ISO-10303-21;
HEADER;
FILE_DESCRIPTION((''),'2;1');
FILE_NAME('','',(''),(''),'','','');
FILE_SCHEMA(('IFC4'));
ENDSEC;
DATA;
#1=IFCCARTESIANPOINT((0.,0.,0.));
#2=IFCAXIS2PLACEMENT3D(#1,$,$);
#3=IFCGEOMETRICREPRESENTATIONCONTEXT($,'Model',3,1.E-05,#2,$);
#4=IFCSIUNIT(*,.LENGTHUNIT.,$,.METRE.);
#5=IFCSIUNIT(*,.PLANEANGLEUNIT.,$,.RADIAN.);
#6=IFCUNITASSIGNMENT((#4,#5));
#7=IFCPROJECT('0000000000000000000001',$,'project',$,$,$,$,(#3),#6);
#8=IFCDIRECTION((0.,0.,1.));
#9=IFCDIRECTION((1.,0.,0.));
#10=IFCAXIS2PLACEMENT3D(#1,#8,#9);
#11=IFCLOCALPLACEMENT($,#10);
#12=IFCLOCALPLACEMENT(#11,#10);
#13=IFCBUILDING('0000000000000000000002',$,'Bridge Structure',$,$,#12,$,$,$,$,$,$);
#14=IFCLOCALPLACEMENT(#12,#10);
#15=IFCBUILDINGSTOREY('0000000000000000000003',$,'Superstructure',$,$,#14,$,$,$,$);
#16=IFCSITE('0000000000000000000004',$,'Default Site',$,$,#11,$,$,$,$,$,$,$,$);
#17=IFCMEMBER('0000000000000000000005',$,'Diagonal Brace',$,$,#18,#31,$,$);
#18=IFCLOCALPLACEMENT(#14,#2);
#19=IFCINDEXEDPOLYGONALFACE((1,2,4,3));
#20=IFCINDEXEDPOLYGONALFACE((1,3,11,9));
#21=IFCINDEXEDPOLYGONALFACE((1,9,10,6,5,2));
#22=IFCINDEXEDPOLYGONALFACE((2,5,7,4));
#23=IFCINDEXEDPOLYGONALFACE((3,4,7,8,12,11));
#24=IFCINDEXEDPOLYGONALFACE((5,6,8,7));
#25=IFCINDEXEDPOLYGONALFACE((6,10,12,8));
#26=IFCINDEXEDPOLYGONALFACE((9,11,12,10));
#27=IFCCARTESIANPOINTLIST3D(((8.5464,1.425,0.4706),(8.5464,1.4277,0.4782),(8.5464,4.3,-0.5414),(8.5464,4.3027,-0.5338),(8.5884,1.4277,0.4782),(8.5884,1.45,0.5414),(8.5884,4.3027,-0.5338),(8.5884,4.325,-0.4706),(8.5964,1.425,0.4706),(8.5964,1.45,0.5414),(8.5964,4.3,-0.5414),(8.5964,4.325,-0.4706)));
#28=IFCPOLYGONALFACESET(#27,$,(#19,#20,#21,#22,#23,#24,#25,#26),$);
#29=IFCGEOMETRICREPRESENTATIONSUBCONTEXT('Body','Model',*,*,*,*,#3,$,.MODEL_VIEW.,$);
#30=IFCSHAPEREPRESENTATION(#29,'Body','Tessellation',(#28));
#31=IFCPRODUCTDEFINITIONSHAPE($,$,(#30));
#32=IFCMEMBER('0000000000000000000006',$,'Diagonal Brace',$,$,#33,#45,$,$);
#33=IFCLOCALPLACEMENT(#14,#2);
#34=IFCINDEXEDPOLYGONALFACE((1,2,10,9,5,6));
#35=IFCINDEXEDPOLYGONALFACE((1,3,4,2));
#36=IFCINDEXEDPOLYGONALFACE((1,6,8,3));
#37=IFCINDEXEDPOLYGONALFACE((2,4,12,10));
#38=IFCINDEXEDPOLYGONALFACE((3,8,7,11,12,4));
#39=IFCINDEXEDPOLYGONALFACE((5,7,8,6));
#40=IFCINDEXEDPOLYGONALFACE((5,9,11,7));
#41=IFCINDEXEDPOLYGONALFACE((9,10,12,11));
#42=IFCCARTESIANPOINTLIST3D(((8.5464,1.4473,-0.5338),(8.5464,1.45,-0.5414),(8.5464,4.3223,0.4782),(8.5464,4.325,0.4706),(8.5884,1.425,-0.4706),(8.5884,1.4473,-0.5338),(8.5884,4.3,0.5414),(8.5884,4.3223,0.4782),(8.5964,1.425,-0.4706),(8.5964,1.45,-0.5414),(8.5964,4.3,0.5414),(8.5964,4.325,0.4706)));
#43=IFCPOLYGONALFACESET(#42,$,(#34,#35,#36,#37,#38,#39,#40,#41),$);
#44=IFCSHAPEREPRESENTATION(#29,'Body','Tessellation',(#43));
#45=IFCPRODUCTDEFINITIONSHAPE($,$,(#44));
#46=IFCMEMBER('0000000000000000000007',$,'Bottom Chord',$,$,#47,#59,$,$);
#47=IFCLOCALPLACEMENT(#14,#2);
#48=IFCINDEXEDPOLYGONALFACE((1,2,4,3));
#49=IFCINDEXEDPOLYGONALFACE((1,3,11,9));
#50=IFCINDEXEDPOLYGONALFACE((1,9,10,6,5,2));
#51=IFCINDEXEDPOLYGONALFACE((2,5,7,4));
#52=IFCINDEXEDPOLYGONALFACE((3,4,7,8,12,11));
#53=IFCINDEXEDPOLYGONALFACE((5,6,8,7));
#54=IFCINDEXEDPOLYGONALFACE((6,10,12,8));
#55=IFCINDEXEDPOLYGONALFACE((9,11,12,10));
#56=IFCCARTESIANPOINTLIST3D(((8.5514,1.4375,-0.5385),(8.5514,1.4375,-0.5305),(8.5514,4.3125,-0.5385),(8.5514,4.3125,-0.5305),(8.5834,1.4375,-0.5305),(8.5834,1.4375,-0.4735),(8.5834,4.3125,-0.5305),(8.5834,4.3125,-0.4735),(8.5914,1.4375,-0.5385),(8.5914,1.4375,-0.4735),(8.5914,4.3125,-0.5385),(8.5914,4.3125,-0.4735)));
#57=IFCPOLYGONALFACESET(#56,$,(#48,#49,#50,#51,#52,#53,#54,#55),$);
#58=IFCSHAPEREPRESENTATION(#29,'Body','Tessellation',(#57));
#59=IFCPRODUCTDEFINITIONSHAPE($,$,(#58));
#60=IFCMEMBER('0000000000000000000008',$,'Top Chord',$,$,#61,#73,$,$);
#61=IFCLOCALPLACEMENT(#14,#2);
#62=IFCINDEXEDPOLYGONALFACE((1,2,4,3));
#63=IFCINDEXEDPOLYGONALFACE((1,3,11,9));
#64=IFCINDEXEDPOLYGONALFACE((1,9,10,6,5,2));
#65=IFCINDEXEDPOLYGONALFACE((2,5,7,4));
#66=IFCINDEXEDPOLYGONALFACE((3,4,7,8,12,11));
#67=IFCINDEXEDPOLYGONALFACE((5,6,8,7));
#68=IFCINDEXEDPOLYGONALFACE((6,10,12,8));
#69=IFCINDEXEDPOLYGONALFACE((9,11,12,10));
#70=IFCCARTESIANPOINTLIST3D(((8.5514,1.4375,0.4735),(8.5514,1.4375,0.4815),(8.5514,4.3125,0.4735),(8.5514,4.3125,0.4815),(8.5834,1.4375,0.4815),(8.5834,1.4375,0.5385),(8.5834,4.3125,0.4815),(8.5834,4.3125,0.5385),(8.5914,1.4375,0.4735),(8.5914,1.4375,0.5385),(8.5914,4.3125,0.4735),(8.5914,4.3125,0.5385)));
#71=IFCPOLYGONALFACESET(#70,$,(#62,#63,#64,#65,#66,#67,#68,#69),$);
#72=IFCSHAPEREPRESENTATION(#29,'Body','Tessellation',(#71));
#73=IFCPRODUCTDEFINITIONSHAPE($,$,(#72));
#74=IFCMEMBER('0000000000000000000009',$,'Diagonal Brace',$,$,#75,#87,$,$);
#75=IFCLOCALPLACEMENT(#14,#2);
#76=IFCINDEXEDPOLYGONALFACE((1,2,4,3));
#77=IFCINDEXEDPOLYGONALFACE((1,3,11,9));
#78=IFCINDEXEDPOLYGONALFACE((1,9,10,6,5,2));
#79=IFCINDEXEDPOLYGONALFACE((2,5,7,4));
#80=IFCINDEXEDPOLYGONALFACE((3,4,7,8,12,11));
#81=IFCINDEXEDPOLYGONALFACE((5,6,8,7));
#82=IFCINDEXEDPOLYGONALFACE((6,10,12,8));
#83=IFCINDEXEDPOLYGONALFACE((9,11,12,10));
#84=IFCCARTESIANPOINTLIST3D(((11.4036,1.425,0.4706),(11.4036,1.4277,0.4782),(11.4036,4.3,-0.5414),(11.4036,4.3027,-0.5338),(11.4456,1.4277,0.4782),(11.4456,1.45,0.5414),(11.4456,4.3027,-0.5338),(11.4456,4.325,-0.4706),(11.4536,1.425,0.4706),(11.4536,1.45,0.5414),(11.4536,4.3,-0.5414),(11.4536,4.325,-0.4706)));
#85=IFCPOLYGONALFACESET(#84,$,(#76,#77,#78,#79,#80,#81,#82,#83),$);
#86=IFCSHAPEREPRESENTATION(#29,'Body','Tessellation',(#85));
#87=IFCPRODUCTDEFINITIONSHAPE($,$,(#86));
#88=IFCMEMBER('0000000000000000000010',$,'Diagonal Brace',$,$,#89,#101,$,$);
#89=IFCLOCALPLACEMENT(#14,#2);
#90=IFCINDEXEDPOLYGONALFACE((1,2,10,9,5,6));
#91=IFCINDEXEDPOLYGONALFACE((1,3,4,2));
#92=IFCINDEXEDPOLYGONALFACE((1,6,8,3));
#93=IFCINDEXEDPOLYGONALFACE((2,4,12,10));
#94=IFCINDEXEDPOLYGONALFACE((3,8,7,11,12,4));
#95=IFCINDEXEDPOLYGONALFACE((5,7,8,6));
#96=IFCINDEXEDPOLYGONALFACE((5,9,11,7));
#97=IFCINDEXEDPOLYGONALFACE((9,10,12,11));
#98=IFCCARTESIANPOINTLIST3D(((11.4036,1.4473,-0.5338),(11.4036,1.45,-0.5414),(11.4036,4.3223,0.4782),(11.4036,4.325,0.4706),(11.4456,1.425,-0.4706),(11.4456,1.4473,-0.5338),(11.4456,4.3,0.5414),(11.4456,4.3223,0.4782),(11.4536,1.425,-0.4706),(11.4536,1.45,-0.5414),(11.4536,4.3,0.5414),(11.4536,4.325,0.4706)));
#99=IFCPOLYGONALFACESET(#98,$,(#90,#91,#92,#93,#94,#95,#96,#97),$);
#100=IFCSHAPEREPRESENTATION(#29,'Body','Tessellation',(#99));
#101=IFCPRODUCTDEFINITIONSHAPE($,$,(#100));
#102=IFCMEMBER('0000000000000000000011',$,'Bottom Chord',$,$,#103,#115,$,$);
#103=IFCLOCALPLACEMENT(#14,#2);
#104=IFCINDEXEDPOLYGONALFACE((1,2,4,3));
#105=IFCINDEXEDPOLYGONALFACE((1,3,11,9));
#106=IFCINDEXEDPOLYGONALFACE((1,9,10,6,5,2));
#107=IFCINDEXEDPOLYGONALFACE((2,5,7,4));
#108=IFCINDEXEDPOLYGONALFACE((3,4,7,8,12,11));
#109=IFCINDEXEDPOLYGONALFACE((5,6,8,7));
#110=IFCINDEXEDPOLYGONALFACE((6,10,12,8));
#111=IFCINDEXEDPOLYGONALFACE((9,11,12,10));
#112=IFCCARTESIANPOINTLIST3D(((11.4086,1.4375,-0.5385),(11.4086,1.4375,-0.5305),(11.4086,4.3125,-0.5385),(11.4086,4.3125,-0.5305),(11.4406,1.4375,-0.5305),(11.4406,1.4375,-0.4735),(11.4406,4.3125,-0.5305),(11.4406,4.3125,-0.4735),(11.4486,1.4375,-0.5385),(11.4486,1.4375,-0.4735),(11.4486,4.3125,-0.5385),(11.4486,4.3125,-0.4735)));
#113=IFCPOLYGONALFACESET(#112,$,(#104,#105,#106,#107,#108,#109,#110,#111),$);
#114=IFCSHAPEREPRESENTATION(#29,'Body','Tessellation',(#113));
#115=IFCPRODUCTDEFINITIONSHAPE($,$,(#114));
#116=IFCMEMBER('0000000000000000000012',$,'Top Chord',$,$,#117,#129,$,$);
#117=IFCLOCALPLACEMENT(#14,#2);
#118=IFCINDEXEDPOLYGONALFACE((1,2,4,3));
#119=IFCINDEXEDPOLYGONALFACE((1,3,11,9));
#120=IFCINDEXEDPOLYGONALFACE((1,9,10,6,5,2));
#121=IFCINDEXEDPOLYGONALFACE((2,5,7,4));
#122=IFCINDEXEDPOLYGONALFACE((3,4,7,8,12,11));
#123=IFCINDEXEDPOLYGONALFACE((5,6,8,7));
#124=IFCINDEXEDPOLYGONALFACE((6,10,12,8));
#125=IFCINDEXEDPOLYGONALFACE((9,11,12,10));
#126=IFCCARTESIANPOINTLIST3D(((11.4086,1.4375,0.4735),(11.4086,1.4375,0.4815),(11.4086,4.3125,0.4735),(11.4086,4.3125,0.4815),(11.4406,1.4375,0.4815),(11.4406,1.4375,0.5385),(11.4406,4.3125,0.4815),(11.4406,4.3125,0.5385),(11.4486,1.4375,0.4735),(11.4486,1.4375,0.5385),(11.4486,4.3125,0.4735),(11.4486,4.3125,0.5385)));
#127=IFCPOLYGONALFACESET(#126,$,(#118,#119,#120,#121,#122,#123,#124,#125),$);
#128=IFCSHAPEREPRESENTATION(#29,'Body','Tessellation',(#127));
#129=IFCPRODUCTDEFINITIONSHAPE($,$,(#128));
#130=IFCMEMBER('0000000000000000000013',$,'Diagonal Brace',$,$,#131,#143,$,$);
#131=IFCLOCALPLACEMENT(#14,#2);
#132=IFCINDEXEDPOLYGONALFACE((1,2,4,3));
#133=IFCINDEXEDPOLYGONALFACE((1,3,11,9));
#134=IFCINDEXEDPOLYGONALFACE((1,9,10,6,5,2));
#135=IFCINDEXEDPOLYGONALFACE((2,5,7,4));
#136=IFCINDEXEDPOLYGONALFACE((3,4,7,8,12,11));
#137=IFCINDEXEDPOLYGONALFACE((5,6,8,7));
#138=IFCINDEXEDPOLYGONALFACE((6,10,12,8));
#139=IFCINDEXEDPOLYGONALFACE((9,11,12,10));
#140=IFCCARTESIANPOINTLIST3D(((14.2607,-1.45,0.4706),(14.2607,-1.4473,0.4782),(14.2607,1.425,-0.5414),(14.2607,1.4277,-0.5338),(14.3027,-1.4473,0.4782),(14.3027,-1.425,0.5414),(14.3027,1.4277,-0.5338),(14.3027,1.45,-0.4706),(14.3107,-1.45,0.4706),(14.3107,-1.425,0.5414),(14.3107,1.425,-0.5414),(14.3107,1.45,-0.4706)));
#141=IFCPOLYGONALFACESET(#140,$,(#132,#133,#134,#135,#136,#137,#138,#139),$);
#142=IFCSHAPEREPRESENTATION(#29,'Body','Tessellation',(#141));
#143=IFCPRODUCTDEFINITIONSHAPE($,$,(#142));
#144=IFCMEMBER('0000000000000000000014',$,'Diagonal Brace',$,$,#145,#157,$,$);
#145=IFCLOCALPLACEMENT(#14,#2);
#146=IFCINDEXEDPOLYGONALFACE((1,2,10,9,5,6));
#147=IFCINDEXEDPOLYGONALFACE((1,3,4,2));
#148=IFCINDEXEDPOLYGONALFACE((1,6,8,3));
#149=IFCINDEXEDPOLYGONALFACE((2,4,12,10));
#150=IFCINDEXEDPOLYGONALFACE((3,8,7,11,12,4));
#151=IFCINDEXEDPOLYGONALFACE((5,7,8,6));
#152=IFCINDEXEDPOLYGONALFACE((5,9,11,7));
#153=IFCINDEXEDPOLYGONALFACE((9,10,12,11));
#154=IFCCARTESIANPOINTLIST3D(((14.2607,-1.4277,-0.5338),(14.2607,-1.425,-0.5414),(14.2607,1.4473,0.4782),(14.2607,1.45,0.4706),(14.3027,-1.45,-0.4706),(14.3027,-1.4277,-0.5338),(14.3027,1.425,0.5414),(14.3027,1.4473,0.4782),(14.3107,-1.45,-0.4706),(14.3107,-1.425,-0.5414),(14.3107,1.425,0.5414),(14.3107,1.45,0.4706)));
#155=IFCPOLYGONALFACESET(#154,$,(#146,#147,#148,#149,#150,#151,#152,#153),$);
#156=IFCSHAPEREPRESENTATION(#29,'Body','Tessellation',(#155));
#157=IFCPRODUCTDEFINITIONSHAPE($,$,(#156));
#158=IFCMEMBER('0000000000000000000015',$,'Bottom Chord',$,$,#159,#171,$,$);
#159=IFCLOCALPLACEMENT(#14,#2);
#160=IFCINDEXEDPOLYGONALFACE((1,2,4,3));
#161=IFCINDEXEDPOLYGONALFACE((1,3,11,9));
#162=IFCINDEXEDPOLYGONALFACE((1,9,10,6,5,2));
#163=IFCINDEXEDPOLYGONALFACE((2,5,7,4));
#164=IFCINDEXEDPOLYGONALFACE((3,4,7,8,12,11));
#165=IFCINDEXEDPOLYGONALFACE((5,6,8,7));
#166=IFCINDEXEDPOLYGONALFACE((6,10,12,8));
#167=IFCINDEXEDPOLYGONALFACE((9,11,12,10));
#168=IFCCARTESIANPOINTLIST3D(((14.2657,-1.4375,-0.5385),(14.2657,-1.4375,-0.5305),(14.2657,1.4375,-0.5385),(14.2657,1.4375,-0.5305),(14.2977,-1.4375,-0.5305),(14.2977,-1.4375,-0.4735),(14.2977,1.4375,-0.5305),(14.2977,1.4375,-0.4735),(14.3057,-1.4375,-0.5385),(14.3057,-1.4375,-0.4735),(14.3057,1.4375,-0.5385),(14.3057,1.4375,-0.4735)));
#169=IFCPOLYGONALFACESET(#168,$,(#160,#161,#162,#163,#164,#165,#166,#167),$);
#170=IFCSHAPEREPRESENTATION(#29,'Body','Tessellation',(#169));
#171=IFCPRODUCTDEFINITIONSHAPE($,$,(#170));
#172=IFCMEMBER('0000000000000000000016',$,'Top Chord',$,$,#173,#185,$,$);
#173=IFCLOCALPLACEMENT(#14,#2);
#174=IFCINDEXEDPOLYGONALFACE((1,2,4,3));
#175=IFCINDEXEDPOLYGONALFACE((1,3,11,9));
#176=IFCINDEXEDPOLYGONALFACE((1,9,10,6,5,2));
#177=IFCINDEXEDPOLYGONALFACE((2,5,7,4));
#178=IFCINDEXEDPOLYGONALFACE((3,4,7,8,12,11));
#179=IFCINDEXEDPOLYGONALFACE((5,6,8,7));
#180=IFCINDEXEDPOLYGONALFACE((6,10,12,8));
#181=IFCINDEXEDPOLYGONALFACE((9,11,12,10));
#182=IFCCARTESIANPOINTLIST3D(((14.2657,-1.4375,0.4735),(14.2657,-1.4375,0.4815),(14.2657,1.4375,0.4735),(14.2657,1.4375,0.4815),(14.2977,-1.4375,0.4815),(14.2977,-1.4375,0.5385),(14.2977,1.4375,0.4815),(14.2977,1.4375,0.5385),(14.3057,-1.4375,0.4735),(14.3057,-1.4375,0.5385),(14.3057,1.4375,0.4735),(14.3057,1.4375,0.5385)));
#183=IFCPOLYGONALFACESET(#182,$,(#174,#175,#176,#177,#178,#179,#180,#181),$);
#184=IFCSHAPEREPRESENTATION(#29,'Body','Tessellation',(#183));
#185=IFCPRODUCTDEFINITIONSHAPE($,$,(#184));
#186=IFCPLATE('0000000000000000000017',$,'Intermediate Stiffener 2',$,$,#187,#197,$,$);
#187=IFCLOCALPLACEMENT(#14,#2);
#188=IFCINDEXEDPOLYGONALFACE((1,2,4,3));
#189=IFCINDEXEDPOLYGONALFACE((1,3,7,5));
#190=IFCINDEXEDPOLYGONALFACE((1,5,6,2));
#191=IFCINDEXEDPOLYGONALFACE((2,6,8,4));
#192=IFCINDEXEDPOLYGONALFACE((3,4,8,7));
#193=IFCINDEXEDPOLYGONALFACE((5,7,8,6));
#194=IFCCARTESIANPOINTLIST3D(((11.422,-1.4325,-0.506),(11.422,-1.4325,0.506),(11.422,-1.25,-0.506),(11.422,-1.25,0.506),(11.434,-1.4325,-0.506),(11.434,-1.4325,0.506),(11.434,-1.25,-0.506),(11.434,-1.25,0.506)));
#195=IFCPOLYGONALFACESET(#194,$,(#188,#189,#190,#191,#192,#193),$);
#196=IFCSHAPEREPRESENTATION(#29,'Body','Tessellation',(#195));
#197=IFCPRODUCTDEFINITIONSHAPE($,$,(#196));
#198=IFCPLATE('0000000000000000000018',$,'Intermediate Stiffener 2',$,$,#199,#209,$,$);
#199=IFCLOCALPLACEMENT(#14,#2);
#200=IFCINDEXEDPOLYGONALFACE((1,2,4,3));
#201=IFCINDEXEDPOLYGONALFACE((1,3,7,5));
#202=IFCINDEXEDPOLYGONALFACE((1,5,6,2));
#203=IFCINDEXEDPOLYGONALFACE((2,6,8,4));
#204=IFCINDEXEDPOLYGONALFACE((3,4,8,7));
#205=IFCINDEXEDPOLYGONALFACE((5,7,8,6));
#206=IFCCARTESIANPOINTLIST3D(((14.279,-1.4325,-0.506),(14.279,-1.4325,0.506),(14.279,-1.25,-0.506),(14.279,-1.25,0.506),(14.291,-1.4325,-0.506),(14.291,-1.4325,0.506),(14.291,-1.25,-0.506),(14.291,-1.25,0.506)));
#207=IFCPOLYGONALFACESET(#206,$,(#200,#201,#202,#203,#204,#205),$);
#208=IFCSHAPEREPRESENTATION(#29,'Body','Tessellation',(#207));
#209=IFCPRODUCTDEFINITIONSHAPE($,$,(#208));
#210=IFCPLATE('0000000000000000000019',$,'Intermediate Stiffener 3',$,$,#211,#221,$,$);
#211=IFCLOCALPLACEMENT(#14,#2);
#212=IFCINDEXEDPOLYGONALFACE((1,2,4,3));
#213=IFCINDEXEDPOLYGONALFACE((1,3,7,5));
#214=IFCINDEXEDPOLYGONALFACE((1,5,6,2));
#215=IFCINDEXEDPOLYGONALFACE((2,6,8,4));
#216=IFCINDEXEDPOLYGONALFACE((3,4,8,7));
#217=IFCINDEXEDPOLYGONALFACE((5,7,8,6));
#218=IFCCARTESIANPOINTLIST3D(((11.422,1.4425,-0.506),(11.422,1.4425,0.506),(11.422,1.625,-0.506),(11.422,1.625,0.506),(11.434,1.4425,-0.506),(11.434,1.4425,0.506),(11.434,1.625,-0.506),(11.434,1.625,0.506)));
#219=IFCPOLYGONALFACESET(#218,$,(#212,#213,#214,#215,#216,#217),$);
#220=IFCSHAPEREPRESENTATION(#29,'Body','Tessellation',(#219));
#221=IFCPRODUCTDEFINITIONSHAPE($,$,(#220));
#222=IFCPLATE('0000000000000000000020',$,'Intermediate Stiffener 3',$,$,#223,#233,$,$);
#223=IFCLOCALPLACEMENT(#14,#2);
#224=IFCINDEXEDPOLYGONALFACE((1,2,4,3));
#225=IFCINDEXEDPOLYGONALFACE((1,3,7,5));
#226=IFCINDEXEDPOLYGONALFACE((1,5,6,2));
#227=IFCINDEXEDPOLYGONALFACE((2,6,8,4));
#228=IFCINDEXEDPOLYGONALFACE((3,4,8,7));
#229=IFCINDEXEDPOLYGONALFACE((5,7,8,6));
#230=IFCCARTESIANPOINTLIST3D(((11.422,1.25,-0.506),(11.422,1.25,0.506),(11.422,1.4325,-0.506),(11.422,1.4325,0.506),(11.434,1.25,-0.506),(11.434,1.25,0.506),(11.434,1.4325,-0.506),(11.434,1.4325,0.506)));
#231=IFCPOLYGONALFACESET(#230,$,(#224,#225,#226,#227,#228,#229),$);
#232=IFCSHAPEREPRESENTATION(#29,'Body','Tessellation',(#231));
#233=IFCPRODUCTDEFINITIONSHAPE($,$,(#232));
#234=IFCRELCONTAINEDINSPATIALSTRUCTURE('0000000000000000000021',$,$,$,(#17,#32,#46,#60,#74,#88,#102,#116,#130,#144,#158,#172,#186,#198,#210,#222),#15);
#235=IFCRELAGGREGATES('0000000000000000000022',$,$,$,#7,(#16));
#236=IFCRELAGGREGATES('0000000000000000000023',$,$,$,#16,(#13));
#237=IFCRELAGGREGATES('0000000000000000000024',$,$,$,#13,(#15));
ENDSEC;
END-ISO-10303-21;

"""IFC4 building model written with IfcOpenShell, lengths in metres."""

from ifc_helpers import new_model, si_unit, frame, origin, origin_with_axes, origin_2d_with_axis, place, context, subcontext, project, spatial, rectangle, l_section, extrude, element, save


model = new_model("IFC4")

# Units and contexts
model_context = context("Model", 3, precision=1e-05, world=origin())
body_context = subcontext(model_context, "Body", "Model", "MODEL_VIEW")
ifc_project = project(units=[si_unit("LENGTHUNIT", "METRE"), si_unit("PLANEANGLEUNIT", "RADIAN")], contexts=[model_context])

# Site, building, storey
site_placement = place(None, origin_with_axes())
site = spatial("IfcSite", under=ifc_project, at=site_placement, Name="Default Site")
building_placement = place(site_placement, origin_with_axes())
building = spatial("IfcBuilding", under=site, at=building_placement, Name="Bridge Structure")
storey_placement = place(building_placement, origin_with_axes())
storey = spatial("IfcBuildingStorey", under=building, at=storey_placement, Name="Superstructure")

# Members
for number, where, z_axis, x_axis, name in (
    (1, (8.5714, 1.4375, 0.506), (0.0, 0.943269, -0.332031), (-1.0, 0.0, 0.0), "Diagonal Brace"),
    (2, (8.5714, 1.4375, -0.506), (0.0, 0.943269, 0.332031), (-1.0, 0.0, 0.0), "Diagonal Brace"),
):
    element("IfcMember", number, at=place(storey_placement, frame(where, z_axis=z_axis, x_axis=x_axis)), inside=storey, Name=name, context=body_context, shape_type="SweptSolid", body=[
        extrude(l_section(Depth=0.075, Width=0.05, Thickness=0.008, at=origin_2d_with_axis()), origin_with_axes(), (0.0, 0.0, 1.0), 3.0479),
    ])
for number, where, z_axis, x_axis, name in (
    (3, (8.5714, 1.4375, -0.506), (0.0, 1.0, 0.0), (-1.0, 0.0, 0.0), "Bottom Chord"),
    (4, (8.5714, 1.4375, 0.506), (0.0, 1.0, 0.0), (-1.0, 0.0, 0.0), "Top Chord"),
):
    element("IfcMember", number, at=place(storey_placement, frame(where, z_axis=z_axis, x_axis=x_axis)), inside=storey, Name=name, context=body_context, shape_type="SweptSolid", body=[
        extrude(l_section(Depth=0.065, Width=0.04, Thickness=0.008, at=origin_2d_with_axis()), origin_with_axes(), (0.0, 0.0, 1.0), 2.875),
    ])
for number, where, z_axis, x_axis, name in (
    (5, (11.4286, 1.4375, 0.506), (0.0, 0.943269, -0.332031), (-1.0, 0.0, 0.0), "Diagonal Brace"),
    (6, (11.4286, 1.4375, -0.506), (0.0, 0.943269, 0.332031), (-1.0, 0.0, 0.0), "Diagonal Brace"),
):
    element("IfcMember", number, at=place(storey_placement, frame(where, z_axis=z_axis, x_axis=x_axis)), inside=storey, Name=name, context=body_context, shape_type="SweptSolid", body=[
        extrude(l_section(Depth=0.075, Width=0.05, Thickness=0.008, at=origin_2d_with_axis()), origin_with_axes(), (0.0, 0.0, 1.0), 3.0479),
    ])
for number, where, z_axis, x_axis, name in (
    (7, (11.4286, 1.4375, -0.506), (0.0, 1.0, 0.0), (-1.0, 0.0, 0.0), "Bottom Chord"),
    (8, (11.4286, 1.4375, 0.506), (0.0, 1.0, 0.0), (-1.0, 0.0, 0.0), "Top Chord"),
):
    element("IfcMember", number, at=place(storey_placement, frame(where, z_axis=z_axis, x_axis=x_axis)), inside=storey, Name=name, context=body_context, shape_type="SweptSolid", body=[
        extrude(l_section(Depth=0.065, Width=0.04, Thickness=0.008, at=origin_2d_with_axis()), origin_with_axes(), (0.0, 0.0, 1.0), 2.875),
    ])
for number, where, z_axis, x_axis, name in (
    (9, (14.2857, -1.4375, 0.506), (0.0, 0.943269, -0.332031), (-1.0, 0.0, 0.0), "Diagonal Brace"),
    (10, (14.2857, -1.4375, -0.506), (0.0, 0.943269, 0.332031), (-1.0, 0.0, 0.0), "Diagonal Brace"),
):
    element("IfcMember", number, at=place(storey_placement, frame(where, z_axis=z_axis, x_axis=x_axis)), inside=storey, Name=name, context=body_context, shape_type="SweptSolid", body=[
        extrude(l_section(Depth=0.075, Width=0.05, Thickness=0.008, at=origin_2d_with_axis()), origin_with_axes(), (0.0, 0.0, 1.0), 3.0479),
    ])
for number, where, z_axis, x_axis, name in (
    (11, (14.2857, -1.4375, -0.506), (0.0, 1.0, 0.0), (-1.0, 0.0, 0.0), "Bottom Chord"),
    (12, (14.2857, -1.4375, 0.506), (0.0, 1.0, 0.0), (-1.0, 0.0, 0.0), "Top Chord"),
):
    element("IfcMember", number, at=place(storey_placement, frame(where, z_axis=z_axis, x_axis=x_axis)), inside=storey, Name=name, context=body_context, shape_type="SweptSolid", body=[
        extrude(l_section(Depth=0.065, Width=0.04, Thickness=0.008, at=origin_2d_with_axis()), origin_with_axes(), (0.0, 0.0, 1.0), 2.875),
    ])

# Plates
for number, where, z_axis, x_axis, name in (
    (13, (11.428, -1.3413, -0.506), (0.0, 0.0, 1.0), (1.0, 0.0, 0.0), "Intermediate Stiffener 2"),
    (14, (14.285, -1.3413, -0.506), (0.0, 0.0, 1.0), (1.0, 0.0, 0.0), "Intermediate Stiffener 2"),
    (15, (11.428, 1.5337, -0.506), (0.0, 0.0, 1.0), (1.0, 0.0, 0.0), "Intermediate Stiffener 3"),
    (16, (11.428, 1.3413, -0.506), (0.0, 0.0, 1.0), (1.0, 0.0, 0.0), "Intermediate Stiffener 3"),
):
    element("IfcPlate", number, at=place(storey_placement, frame(where, z_axis=z_axis, x_axis=x_axis)), inside=storey, Name=name, context=body_context, shape_type="SweptSolid", body=[
        extrude(rectangle(XDim=0.012, YDim=0.1825, at=origin_2d_with_axis()), origin_with_axes(), (0.0, 0.0, 1.0), 1.012),
    ])

save(model, "model.ifc")
